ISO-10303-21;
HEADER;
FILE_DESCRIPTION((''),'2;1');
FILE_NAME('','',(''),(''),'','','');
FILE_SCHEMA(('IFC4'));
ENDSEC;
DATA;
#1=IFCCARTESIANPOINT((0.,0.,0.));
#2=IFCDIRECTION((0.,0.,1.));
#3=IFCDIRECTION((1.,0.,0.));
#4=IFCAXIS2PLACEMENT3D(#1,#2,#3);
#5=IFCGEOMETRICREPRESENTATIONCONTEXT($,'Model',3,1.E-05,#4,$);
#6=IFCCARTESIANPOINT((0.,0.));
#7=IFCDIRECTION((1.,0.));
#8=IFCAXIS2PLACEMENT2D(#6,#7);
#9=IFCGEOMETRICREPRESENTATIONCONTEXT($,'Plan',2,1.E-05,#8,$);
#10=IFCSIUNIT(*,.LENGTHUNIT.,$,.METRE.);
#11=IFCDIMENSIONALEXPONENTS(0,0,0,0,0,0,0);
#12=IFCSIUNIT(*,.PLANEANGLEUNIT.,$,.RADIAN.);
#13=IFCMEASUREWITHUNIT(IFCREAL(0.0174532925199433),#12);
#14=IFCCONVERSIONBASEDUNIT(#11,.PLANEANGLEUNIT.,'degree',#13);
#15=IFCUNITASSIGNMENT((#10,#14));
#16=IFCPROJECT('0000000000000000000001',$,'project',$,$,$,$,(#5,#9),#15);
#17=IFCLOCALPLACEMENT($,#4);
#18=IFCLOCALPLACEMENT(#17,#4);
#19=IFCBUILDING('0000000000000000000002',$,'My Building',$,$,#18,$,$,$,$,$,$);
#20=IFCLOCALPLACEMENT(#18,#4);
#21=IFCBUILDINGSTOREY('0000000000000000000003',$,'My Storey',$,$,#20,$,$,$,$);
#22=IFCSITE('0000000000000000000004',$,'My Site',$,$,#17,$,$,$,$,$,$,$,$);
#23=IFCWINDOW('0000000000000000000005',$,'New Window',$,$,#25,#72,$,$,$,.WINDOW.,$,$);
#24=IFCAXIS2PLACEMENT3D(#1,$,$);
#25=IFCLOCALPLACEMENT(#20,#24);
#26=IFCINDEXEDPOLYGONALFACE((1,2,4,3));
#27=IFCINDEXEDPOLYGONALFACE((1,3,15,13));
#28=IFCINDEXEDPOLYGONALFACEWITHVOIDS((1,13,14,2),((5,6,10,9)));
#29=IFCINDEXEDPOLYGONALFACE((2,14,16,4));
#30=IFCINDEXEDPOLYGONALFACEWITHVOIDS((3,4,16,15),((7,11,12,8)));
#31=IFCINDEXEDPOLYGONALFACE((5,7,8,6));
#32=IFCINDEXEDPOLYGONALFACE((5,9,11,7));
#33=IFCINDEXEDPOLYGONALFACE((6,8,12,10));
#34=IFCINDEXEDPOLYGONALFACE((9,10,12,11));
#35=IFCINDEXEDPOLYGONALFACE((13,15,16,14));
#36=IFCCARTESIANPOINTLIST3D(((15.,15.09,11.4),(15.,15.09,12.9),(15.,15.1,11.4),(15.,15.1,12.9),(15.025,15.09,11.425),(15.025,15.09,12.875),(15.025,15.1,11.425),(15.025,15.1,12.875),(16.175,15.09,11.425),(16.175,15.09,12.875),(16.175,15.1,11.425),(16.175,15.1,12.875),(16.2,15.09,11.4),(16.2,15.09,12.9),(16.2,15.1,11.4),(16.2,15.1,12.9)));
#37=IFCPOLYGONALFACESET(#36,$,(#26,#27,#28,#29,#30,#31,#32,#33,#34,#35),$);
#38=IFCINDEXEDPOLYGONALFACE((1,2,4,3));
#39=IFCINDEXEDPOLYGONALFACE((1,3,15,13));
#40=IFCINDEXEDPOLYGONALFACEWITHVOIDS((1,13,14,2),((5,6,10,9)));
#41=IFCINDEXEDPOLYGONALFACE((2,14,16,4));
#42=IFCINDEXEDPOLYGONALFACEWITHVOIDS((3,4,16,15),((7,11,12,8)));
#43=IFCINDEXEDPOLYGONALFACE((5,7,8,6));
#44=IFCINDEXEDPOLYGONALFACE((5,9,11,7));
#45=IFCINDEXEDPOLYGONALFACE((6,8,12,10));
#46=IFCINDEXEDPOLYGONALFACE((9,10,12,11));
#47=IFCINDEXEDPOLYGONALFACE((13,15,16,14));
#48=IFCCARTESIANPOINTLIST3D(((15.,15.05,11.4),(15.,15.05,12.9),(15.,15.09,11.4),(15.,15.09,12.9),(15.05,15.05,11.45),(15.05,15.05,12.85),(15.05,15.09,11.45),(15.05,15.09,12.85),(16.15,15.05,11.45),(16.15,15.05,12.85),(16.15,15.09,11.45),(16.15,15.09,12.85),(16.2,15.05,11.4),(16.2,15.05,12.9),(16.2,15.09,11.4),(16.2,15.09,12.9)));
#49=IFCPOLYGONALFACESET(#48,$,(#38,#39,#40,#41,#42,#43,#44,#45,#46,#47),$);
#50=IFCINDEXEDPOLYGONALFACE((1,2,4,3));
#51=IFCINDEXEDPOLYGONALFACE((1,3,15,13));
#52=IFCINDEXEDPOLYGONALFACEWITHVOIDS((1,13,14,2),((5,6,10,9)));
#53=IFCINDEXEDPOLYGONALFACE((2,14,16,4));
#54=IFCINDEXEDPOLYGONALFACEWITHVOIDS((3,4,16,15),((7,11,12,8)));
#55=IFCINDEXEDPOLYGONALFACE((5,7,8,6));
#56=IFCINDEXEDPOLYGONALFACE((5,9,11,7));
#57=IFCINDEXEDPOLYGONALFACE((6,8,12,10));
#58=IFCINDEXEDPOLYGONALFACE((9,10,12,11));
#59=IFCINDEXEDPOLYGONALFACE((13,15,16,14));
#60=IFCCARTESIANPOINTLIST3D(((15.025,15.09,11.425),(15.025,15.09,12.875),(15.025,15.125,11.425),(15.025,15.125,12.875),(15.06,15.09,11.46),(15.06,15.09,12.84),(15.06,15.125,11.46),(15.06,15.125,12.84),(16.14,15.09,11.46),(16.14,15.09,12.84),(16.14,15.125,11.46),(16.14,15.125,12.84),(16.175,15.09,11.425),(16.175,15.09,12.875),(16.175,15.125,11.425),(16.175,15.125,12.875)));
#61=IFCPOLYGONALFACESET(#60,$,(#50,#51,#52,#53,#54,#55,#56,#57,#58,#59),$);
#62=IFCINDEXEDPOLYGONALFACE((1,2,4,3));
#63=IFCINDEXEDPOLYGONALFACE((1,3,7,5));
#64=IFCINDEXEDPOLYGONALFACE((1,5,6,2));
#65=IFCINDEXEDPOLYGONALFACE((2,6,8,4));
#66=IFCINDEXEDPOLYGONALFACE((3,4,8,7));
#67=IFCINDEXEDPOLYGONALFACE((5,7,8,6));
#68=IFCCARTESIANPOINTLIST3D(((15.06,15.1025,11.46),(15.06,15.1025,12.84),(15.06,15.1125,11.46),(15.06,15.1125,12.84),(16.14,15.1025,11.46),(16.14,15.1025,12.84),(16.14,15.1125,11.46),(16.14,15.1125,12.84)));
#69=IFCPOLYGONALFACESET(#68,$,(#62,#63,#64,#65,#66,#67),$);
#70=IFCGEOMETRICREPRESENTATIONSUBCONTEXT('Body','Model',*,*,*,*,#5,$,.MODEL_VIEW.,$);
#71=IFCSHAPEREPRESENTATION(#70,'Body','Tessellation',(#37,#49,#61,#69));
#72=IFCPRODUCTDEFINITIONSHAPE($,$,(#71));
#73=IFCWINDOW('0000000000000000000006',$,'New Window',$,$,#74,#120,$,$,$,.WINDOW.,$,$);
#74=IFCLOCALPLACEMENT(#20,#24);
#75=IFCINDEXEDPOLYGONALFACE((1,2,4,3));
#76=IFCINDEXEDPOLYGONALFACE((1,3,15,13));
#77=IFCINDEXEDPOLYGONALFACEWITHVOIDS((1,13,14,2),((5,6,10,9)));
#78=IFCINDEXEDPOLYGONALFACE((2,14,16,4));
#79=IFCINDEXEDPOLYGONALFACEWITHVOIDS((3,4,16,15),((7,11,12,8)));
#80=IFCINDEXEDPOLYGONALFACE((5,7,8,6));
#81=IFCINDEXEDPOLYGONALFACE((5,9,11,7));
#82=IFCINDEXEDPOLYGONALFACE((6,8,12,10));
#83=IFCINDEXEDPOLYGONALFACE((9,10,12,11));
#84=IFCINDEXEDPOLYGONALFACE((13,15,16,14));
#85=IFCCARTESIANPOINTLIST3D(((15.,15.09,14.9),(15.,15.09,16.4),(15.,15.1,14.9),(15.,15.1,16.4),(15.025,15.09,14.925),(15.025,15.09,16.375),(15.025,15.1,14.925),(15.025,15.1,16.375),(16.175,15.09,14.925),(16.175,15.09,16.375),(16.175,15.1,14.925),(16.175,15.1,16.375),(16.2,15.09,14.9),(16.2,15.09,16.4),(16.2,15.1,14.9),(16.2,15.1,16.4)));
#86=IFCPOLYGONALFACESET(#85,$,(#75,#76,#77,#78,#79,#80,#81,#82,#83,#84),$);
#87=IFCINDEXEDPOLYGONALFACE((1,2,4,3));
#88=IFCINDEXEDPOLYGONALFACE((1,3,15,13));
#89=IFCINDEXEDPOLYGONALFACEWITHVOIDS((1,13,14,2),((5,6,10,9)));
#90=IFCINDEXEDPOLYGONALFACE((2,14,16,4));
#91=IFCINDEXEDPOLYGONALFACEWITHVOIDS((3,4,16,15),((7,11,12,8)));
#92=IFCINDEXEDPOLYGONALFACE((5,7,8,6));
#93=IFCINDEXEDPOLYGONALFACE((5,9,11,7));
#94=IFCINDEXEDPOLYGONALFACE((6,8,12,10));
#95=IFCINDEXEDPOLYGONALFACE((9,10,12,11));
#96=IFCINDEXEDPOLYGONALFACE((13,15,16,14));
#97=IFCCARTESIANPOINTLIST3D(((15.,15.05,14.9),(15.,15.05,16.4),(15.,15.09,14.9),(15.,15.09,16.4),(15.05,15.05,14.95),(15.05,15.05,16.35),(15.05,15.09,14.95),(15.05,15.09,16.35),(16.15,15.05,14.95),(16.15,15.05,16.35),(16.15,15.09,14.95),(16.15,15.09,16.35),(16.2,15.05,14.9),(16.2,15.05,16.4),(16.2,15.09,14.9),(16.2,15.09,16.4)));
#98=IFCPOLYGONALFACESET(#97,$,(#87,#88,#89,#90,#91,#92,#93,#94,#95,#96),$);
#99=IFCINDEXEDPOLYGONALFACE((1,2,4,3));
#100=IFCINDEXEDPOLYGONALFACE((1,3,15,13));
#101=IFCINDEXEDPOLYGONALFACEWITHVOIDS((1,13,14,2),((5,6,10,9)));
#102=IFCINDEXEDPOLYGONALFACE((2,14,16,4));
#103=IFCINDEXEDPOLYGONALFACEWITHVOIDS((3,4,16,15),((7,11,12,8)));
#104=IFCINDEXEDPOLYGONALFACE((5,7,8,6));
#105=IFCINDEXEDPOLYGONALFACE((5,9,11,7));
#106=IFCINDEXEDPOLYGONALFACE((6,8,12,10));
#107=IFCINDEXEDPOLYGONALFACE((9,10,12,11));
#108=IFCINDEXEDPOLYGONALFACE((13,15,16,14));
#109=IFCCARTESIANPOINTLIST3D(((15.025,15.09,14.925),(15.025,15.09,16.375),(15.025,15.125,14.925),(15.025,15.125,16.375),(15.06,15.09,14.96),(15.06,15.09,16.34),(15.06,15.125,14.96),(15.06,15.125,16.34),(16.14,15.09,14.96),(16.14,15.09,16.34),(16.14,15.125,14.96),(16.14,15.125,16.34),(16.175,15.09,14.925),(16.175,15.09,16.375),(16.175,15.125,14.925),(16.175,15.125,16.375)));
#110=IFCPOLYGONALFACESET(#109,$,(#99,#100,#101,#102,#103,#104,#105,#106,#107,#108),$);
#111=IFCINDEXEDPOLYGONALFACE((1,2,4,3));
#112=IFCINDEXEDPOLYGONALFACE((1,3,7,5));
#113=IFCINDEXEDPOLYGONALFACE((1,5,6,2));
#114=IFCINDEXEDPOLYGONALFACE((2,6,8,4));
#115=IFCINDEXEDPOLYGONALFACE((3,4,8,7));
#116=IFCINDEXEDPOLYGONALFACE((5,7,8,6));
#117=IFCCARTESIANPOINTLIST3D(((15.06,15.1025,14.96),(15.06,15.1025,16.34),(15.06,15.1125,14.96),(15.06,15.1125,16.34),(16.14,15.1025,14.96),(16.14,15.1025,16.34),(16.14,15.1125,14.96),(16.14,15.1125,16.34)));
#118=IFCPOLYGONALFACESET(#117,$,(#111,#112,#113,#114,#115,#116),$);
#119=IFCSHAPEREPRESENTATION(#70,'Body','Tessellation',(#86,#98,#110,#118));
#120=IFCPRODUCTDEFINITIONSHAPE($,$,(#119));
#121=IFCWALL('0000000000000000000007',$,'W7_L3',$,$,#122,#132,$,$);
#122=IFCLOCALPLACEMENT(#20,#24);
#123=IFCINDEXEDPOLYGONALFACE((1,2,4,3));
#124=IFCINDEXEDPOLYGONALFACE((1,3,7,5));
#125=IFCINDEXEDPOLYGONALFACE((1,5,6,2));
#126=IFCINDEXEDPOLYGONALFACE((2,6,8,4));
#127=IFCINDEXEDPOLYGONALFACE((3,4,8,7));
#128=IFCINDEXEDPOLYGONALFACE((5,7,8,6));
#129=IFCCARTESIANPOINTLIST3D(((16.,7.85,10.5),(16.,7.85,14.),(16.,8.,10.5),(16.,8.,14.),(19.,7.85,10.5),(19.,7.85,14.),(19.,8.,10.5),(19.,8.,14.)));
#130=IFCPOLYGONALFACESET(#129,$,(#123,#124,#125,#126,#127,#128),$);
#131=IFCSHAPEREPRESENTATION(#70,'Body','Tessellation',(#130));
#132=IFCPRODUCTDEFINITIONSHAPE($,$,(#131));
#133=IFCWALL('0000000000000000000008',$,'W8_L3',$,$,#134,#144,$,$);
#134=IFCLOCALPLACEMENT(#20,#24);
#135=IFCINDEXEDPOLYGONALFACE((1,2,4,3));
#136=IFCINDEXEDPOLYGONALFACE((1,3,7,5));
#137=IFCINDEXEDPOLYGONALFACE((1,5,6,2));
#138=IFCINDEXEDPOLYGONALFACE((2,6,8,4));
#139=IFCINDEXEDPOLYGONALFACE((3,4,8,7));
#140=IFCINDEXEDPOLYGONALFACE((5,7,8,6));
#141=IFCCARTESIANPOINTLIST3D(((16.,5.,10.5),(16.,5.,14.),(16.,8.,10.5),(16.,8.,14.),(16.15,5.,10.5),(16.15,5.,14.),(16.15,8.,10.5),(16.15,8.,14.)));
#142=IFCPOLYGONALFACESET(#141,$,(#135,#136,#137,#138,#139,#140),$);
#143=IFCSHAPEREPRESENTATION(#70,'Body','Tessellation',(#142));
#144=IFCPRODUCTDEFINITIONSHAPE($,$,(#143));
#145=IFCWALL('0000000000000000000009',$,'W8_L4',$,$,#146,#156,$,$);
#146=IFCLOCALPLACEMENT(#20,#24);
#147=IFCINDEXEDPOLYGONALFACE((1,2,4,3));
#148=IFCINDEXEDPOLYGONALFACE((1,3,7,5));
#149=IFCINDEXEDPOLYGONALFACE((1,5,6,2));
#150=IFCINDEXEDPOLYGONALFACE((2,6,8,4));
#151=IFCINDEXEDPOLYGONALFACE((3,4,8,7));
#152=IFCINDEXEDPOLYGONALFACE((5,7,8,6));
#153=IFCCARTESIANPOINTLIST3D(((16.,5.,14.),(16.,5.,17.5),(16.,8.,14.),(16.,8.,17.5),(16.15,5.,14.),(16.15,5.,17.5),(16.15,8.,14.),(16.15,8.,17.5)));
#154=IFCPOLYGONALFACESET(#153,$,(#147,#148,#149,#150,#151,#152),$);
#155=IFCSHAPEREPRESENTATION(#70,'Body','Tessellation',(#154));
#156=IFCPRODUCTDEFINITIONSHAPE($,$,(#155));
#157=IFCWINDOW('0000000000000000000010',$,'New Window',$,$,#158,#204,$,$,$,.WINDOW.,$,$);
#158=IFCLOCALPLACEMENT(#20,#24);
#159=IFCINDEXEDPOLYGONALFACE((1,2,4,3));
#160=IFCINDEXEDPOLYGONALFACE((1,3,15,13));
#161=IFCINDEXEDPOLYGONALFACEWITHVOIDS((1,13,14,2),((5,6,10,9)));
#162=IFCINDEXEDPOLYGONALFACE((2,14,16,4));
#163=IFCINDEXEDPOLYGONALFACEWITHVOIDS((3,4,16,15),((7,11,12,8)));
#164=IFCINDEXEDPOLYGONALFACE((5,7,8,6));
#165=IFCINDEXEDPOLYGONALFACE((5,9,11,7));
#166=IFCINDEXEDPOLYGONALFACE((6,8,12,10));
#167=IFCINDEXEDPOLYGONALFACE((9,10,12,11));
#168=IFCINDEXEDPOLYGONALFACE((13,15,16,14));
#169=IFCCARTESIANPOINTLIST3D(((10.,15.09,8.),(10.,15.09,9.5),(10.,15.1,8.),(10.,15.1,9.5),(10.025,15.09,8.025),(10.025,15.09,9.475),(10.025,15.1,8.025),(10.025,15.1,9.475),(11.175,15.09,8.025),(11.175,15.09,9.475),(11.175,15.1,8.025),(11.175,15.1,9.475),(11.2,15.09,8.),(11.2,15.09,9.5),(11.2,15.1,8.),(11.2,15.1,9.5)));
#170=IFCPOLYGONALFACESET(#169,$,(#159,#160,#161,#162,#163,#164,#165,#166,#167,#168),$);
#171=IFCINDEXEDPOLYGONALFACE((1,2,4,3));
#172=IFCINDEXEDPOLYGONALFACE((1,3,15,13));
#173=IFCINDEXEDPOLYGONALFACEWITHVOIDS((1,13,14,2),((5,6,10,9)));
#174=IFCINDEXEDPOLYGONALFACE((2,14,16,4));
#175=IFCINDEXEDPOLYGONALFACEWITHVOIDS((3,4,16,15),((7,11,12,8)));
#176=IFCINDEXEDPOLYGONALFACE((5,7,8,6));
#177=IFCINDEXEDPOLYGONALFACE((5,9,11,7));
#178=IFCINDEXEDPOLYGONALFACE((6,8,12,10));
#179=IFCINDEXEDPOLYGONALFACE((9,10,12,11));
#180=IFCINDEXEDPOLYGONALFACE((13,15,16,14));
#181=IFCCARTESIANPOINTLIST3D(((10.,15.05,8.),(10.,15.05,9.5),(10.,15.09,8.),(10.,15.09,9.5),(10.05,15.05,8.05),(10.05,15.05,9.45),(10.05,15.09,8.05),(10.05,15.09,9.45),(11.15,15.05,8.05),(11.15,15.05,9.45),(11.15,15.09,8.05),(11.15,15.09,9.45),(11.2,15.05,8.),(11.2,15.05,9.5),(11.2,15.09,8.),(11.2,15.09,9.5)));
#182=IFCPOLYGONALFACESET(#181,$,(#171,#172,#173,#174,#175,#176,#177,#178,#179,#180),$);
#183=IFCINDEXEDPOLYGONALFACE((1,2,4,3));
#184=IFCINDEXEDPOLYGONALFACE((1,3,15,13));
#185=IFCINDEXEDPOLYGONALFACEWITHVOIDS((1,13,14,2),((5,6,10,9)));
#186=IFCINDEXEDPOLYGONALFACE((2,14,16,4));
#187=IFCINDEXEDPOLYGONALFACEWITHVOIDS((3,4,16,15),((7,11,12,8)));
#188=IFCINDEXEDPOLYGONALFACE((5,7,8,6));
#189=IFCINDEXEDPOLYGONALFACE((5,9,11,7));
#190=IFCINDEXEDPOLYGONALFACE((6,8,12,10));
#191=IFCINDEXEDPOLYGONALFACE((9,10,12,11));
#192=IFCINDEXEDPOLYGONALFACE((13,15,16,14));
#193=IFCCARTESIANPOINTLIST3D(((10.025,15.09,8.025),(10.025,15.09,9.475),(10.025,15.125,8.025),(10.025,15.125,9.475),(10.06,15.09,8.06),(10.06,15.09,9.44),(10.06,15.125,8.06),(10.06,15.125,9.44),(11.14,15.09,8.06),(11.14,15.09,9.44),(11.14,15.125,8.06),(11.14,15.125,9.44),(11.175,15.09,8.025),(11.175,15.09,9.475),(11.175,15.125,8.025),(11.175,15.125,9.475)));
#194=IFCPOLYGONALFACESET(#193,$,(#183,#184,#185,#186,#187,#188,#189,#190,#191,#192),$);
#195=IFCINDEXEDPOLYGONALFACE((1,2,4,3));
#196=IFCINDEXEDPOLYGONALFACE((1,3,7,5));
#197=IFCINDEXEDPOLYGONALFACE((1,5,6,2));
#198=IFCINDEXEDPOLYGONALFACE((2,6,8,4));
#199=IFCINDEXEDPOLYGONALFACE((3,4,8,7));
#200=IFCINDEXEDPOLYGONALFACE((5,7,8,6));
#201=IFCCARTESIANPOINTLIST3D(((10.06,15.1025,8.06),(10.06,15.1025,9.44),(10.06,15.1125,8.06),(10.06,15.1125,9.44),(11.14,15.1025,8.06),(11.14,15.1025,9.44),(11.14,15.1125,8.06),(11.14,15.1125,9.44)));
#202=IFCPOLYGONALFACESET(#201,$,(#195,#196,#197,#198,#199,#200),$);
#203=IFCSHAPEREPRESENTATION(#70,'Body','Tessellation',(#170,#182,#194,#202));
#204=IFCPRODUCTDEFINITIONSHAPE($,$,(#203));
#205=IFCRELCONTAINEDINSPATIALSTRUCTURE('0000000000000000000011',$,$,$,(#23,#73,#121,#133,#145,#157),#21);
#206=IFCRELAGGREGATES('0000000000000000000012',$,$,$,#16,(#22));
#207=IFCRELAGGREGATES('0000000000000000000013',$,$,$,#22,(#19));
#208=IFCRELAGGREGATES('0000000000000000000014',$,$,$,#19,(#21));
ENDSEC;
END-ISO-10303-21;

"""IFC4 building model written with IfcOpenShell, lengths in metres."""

from ifc_helpers import new_model, entity, si_unit, converted_unit, frame, origin_with_axes, origin_2d_with_axis, place, context, subcontext, project, spatial, line, indexed_curve, outline, extrude, element, save


model = new_model("IFC4")

# Units and contexts
model_context = context("Model", 3, precision=1e-05, world=origin_with_axes())
plan_context = context("Plan", 2, precision=1e-05, world=origin_2d_with_axis())
body_context = subcontext(model_context, "Body", "Model", "MODEL_VIEW")
ifc_project = project(units=[si_unit("LENGTHUNIT", "METRE"), converted_unit("PLANEANGLEUNIT", "degree", entity("IfcReal", 0.0174532925199433), si_unit("PLANEANGLEUNIT", "RADIAN"), dimensions=[0, 0, 0, 0, 0, 0, 0])], contexts=[model_context, plan_context])

# Site, building, storey
site_placement = place(None, origin_with_axes())
site = spatial("IfcSite", under=ifc_project, at=site_placement, Name="My Site")
building_placement = place(site_placement, origin_with_axes())
building = spatial("IfcBuilding", under=site, at=building_placement, Name="My Building")
storey_placement = place(building_placement, origin_with_axes())
storey = spatial("IfcBuildingStorey", under=building, at=storey_placement, Name="My Storey")

# Windows
for number, where, z_axis, x_axis, name in (
    (1, (15.0, 15.0, 11.4), (0.0, 0.0, 1.0), (1.0, 0.0, 0.0), "New Window"),
    (2, (15.0, 15.0, 14.9), (0.0, 0.0, 1.0), (1.0, 0.0, 0.0), "New Window"),
):
    element("IfcWindow", number, at=place(storey_placement, frame(where, z_axis=z_axis, x_axis=x_axis)), inside=storey, Name=name, PredefinedType="WINDOW", context=body_context, shape_type="SweptSolid", body=[
        extrude(outline(indexed_curve([(0.0, 0.0), (1.2, 0.0), (1.2, 1.5), (0.0, 1.5)], segments=[line(1, 2, 3, 4, 1)]), holes=[indexed_curve([(0.025, 0.025), (1.175, 0.025), (1.175, 1.475), (0.025, 1.475)], segments=[line(1, 2, 3, 4, 1)])]), frame((0.0, 0.09, 0.0), z_axis=(0.0, -1.0, 0.0), x_axis=(1.0, 0.0, 0.0)), (0.0, 0.0, -1.0), 0.01),
        extrude(outline(indexed_curve([(0.0, 0.0), (1.2, 0.0), (1.2, 1.5), (0.0, 1.5)], segments=[line(1, 2, 3, 4, 1)]), holes=[indexed_curve([(0.05, 0.05), (1.15, 0.05), (1.15, 1.45), (0.05, 1.45)], segments=[line(1, 2, 3, 4, 1)])]), frame((0.0, 0.05, 0.0), z_axis=(0.0, -1.0, 0.0), x_axis=(1.0, 0.0, 0.0)), (0.0, 0.0, -1.0), 0.04),
        extrude(outline(indexed_curve([(0.0, 0.0), (1.15, 0.0), (1.15, 1.45), (0.0, 1.45)], segments=[line(1, 2, 3, 4, 1)]), holes=[indexed_curve([(0.035, 0.035), (1.115, 0.035), (1.115, 1.415), (0.035, 1.415)], segments=[line(1, 2, 3, 4, 1)])]), frame((0.025, 0.09, 0.025), z_axis=(0.0, -1.0, 0.0), x_axis=(1.0, 0.0, 0.0)), (0.0, 0.0, -1.0), 0.035),
        extrude(outline(indexed_curve([(0.035, 0.035), (1.115, 0.035), (1.115, 1.415), (0.035, 1.415)], segments=[line(1, 2, 3, 4, 1)])), frame((0.025, 0.1025, 0.025), z_axis=(0.0, -1.0, 0.0), x_axis=(1.0, 0.0, 0.0)), (0.0, 0.0, -1.0), 0.01),
    ])

# Walls
for number, where, z_axis, x_axis, name in (
    (3, (19.0, 8.0, 10.5), (0.0, 0.0, 1.0), (-1.0, 0.0, 0.0), "W7_L3"),
    (4, (16.0, 8.0, 10.5), (0.0, 0.0, 1.0), (0.0, -1.0, 0.0), "W8_L3"),
    (5, (16.0, 8.0, 14.0), (0.0, 0.0, 1.0), (0.0, -1.0, 0.0), "W8_L4"),
):
    element("IfcWall", number, at=place(storey_placement, frame(where, z_axis=z_axis, x_axis=x_axis)), inside=storey, Name=name, context=body_context, shape_type="SweptSolid", body=[
        extrude(outline(indexed_curve([(0.0, 0.0), (0.0, 0.15), (3.0, 0.15), (3.0, 0.0), (0.0, 0.0)], self_intersect=False)), origin_with_axes(), (0.0, 0.0, 1.0), 3.5),
    ])

# Window
for number, where, z_axis, x_axis, name in (
    (6, (10.0, 15.0, 8.0), (0.0, 0.0, 1.0), (1.0, 0.0, 0.0), "New Window"),
):
    element("IfcWindow", number, at=place(storey_placement, frame(where, z_axis=z_axis, x_axis=x_axis)), inside=storey, Name=name, PredefinedType="WINDOW", context=body_context, shape_type="SweptSolid", body=[
        extrude(outline(indexed_curve([(0.0, 0.0), (1.2, 0.0), (1.2, 1.5), (0.0, 1.5)], segments=[line(1, 2, 3, 4, 1)]), holes=[indexed_curve([(0.025, 0.025), (1.175, 0.025), (1.175, 1.475), (0.025, 1.475)], segments=[line(1, 2, 3, 4, 1)])]), frame((0.0, 0.09, 0.0), z_axis=(0.0, -1.0, 0.0), x_axis=(1.0, 0.0, 0.0)), (0.0, 0.0, -1.0), 0.01),
        extrude(outline(indexed_curve([(0.0, 0.0), (1.2, 0.0), (1.2, 1.5), (0.0, 1.5)], segments=[line(1, 2, 3, 4, 1)]), holes=[indexed_curve([(0.05, 0.05), (1.15, 0.05), (1.15, 1.45), (0.05, 1.45)], segments=[line(1, 2, 3, 4, 1)])]), frame((0.0, 0.05, 0.0), z_axis=(0.0, -1.0, 0.0), x_axis=(1.0, 0.0, 0.0)), (0.0, 0.0, -1.0), 0.04),
        extrude(outline(indexed_curve([(0.0, 0.0), (1.15, 0.0), (1.15, 1.45), (0.0, 1.45)], segments=[line(1, 2, 3, 4, 1)]), holes=[indexed_curve([(0.035, 0.035), (1.115, 0.035), (1.115, 1.415), (0.035, 1.415)], segments=[line(1, 2, 3, 4, 1)])]), frame((0.025, 0.09, 0.025), z_axis=(0.0, -1.0, 0.0), x_axis=(1.0, 0.0, 0.0)), (0.0, 0.0, -1.0), 0.035),
        extrude(outline(indexed_curve([(0.035, 0.035), (1.115, 0.035), (1.115, 1.415), (0.035, 1.415)], segments=[line(1, 2, 3, 4, 1)])), frame((0.025, 0.1025, 0.025), z_axis=(0.0, -1.0, 0.0), x_axis=(1.0, 0.0, 0.0)), (0.0, 0.0, -1.0), 0.01),
    ])

save(model, "model.ifc")
